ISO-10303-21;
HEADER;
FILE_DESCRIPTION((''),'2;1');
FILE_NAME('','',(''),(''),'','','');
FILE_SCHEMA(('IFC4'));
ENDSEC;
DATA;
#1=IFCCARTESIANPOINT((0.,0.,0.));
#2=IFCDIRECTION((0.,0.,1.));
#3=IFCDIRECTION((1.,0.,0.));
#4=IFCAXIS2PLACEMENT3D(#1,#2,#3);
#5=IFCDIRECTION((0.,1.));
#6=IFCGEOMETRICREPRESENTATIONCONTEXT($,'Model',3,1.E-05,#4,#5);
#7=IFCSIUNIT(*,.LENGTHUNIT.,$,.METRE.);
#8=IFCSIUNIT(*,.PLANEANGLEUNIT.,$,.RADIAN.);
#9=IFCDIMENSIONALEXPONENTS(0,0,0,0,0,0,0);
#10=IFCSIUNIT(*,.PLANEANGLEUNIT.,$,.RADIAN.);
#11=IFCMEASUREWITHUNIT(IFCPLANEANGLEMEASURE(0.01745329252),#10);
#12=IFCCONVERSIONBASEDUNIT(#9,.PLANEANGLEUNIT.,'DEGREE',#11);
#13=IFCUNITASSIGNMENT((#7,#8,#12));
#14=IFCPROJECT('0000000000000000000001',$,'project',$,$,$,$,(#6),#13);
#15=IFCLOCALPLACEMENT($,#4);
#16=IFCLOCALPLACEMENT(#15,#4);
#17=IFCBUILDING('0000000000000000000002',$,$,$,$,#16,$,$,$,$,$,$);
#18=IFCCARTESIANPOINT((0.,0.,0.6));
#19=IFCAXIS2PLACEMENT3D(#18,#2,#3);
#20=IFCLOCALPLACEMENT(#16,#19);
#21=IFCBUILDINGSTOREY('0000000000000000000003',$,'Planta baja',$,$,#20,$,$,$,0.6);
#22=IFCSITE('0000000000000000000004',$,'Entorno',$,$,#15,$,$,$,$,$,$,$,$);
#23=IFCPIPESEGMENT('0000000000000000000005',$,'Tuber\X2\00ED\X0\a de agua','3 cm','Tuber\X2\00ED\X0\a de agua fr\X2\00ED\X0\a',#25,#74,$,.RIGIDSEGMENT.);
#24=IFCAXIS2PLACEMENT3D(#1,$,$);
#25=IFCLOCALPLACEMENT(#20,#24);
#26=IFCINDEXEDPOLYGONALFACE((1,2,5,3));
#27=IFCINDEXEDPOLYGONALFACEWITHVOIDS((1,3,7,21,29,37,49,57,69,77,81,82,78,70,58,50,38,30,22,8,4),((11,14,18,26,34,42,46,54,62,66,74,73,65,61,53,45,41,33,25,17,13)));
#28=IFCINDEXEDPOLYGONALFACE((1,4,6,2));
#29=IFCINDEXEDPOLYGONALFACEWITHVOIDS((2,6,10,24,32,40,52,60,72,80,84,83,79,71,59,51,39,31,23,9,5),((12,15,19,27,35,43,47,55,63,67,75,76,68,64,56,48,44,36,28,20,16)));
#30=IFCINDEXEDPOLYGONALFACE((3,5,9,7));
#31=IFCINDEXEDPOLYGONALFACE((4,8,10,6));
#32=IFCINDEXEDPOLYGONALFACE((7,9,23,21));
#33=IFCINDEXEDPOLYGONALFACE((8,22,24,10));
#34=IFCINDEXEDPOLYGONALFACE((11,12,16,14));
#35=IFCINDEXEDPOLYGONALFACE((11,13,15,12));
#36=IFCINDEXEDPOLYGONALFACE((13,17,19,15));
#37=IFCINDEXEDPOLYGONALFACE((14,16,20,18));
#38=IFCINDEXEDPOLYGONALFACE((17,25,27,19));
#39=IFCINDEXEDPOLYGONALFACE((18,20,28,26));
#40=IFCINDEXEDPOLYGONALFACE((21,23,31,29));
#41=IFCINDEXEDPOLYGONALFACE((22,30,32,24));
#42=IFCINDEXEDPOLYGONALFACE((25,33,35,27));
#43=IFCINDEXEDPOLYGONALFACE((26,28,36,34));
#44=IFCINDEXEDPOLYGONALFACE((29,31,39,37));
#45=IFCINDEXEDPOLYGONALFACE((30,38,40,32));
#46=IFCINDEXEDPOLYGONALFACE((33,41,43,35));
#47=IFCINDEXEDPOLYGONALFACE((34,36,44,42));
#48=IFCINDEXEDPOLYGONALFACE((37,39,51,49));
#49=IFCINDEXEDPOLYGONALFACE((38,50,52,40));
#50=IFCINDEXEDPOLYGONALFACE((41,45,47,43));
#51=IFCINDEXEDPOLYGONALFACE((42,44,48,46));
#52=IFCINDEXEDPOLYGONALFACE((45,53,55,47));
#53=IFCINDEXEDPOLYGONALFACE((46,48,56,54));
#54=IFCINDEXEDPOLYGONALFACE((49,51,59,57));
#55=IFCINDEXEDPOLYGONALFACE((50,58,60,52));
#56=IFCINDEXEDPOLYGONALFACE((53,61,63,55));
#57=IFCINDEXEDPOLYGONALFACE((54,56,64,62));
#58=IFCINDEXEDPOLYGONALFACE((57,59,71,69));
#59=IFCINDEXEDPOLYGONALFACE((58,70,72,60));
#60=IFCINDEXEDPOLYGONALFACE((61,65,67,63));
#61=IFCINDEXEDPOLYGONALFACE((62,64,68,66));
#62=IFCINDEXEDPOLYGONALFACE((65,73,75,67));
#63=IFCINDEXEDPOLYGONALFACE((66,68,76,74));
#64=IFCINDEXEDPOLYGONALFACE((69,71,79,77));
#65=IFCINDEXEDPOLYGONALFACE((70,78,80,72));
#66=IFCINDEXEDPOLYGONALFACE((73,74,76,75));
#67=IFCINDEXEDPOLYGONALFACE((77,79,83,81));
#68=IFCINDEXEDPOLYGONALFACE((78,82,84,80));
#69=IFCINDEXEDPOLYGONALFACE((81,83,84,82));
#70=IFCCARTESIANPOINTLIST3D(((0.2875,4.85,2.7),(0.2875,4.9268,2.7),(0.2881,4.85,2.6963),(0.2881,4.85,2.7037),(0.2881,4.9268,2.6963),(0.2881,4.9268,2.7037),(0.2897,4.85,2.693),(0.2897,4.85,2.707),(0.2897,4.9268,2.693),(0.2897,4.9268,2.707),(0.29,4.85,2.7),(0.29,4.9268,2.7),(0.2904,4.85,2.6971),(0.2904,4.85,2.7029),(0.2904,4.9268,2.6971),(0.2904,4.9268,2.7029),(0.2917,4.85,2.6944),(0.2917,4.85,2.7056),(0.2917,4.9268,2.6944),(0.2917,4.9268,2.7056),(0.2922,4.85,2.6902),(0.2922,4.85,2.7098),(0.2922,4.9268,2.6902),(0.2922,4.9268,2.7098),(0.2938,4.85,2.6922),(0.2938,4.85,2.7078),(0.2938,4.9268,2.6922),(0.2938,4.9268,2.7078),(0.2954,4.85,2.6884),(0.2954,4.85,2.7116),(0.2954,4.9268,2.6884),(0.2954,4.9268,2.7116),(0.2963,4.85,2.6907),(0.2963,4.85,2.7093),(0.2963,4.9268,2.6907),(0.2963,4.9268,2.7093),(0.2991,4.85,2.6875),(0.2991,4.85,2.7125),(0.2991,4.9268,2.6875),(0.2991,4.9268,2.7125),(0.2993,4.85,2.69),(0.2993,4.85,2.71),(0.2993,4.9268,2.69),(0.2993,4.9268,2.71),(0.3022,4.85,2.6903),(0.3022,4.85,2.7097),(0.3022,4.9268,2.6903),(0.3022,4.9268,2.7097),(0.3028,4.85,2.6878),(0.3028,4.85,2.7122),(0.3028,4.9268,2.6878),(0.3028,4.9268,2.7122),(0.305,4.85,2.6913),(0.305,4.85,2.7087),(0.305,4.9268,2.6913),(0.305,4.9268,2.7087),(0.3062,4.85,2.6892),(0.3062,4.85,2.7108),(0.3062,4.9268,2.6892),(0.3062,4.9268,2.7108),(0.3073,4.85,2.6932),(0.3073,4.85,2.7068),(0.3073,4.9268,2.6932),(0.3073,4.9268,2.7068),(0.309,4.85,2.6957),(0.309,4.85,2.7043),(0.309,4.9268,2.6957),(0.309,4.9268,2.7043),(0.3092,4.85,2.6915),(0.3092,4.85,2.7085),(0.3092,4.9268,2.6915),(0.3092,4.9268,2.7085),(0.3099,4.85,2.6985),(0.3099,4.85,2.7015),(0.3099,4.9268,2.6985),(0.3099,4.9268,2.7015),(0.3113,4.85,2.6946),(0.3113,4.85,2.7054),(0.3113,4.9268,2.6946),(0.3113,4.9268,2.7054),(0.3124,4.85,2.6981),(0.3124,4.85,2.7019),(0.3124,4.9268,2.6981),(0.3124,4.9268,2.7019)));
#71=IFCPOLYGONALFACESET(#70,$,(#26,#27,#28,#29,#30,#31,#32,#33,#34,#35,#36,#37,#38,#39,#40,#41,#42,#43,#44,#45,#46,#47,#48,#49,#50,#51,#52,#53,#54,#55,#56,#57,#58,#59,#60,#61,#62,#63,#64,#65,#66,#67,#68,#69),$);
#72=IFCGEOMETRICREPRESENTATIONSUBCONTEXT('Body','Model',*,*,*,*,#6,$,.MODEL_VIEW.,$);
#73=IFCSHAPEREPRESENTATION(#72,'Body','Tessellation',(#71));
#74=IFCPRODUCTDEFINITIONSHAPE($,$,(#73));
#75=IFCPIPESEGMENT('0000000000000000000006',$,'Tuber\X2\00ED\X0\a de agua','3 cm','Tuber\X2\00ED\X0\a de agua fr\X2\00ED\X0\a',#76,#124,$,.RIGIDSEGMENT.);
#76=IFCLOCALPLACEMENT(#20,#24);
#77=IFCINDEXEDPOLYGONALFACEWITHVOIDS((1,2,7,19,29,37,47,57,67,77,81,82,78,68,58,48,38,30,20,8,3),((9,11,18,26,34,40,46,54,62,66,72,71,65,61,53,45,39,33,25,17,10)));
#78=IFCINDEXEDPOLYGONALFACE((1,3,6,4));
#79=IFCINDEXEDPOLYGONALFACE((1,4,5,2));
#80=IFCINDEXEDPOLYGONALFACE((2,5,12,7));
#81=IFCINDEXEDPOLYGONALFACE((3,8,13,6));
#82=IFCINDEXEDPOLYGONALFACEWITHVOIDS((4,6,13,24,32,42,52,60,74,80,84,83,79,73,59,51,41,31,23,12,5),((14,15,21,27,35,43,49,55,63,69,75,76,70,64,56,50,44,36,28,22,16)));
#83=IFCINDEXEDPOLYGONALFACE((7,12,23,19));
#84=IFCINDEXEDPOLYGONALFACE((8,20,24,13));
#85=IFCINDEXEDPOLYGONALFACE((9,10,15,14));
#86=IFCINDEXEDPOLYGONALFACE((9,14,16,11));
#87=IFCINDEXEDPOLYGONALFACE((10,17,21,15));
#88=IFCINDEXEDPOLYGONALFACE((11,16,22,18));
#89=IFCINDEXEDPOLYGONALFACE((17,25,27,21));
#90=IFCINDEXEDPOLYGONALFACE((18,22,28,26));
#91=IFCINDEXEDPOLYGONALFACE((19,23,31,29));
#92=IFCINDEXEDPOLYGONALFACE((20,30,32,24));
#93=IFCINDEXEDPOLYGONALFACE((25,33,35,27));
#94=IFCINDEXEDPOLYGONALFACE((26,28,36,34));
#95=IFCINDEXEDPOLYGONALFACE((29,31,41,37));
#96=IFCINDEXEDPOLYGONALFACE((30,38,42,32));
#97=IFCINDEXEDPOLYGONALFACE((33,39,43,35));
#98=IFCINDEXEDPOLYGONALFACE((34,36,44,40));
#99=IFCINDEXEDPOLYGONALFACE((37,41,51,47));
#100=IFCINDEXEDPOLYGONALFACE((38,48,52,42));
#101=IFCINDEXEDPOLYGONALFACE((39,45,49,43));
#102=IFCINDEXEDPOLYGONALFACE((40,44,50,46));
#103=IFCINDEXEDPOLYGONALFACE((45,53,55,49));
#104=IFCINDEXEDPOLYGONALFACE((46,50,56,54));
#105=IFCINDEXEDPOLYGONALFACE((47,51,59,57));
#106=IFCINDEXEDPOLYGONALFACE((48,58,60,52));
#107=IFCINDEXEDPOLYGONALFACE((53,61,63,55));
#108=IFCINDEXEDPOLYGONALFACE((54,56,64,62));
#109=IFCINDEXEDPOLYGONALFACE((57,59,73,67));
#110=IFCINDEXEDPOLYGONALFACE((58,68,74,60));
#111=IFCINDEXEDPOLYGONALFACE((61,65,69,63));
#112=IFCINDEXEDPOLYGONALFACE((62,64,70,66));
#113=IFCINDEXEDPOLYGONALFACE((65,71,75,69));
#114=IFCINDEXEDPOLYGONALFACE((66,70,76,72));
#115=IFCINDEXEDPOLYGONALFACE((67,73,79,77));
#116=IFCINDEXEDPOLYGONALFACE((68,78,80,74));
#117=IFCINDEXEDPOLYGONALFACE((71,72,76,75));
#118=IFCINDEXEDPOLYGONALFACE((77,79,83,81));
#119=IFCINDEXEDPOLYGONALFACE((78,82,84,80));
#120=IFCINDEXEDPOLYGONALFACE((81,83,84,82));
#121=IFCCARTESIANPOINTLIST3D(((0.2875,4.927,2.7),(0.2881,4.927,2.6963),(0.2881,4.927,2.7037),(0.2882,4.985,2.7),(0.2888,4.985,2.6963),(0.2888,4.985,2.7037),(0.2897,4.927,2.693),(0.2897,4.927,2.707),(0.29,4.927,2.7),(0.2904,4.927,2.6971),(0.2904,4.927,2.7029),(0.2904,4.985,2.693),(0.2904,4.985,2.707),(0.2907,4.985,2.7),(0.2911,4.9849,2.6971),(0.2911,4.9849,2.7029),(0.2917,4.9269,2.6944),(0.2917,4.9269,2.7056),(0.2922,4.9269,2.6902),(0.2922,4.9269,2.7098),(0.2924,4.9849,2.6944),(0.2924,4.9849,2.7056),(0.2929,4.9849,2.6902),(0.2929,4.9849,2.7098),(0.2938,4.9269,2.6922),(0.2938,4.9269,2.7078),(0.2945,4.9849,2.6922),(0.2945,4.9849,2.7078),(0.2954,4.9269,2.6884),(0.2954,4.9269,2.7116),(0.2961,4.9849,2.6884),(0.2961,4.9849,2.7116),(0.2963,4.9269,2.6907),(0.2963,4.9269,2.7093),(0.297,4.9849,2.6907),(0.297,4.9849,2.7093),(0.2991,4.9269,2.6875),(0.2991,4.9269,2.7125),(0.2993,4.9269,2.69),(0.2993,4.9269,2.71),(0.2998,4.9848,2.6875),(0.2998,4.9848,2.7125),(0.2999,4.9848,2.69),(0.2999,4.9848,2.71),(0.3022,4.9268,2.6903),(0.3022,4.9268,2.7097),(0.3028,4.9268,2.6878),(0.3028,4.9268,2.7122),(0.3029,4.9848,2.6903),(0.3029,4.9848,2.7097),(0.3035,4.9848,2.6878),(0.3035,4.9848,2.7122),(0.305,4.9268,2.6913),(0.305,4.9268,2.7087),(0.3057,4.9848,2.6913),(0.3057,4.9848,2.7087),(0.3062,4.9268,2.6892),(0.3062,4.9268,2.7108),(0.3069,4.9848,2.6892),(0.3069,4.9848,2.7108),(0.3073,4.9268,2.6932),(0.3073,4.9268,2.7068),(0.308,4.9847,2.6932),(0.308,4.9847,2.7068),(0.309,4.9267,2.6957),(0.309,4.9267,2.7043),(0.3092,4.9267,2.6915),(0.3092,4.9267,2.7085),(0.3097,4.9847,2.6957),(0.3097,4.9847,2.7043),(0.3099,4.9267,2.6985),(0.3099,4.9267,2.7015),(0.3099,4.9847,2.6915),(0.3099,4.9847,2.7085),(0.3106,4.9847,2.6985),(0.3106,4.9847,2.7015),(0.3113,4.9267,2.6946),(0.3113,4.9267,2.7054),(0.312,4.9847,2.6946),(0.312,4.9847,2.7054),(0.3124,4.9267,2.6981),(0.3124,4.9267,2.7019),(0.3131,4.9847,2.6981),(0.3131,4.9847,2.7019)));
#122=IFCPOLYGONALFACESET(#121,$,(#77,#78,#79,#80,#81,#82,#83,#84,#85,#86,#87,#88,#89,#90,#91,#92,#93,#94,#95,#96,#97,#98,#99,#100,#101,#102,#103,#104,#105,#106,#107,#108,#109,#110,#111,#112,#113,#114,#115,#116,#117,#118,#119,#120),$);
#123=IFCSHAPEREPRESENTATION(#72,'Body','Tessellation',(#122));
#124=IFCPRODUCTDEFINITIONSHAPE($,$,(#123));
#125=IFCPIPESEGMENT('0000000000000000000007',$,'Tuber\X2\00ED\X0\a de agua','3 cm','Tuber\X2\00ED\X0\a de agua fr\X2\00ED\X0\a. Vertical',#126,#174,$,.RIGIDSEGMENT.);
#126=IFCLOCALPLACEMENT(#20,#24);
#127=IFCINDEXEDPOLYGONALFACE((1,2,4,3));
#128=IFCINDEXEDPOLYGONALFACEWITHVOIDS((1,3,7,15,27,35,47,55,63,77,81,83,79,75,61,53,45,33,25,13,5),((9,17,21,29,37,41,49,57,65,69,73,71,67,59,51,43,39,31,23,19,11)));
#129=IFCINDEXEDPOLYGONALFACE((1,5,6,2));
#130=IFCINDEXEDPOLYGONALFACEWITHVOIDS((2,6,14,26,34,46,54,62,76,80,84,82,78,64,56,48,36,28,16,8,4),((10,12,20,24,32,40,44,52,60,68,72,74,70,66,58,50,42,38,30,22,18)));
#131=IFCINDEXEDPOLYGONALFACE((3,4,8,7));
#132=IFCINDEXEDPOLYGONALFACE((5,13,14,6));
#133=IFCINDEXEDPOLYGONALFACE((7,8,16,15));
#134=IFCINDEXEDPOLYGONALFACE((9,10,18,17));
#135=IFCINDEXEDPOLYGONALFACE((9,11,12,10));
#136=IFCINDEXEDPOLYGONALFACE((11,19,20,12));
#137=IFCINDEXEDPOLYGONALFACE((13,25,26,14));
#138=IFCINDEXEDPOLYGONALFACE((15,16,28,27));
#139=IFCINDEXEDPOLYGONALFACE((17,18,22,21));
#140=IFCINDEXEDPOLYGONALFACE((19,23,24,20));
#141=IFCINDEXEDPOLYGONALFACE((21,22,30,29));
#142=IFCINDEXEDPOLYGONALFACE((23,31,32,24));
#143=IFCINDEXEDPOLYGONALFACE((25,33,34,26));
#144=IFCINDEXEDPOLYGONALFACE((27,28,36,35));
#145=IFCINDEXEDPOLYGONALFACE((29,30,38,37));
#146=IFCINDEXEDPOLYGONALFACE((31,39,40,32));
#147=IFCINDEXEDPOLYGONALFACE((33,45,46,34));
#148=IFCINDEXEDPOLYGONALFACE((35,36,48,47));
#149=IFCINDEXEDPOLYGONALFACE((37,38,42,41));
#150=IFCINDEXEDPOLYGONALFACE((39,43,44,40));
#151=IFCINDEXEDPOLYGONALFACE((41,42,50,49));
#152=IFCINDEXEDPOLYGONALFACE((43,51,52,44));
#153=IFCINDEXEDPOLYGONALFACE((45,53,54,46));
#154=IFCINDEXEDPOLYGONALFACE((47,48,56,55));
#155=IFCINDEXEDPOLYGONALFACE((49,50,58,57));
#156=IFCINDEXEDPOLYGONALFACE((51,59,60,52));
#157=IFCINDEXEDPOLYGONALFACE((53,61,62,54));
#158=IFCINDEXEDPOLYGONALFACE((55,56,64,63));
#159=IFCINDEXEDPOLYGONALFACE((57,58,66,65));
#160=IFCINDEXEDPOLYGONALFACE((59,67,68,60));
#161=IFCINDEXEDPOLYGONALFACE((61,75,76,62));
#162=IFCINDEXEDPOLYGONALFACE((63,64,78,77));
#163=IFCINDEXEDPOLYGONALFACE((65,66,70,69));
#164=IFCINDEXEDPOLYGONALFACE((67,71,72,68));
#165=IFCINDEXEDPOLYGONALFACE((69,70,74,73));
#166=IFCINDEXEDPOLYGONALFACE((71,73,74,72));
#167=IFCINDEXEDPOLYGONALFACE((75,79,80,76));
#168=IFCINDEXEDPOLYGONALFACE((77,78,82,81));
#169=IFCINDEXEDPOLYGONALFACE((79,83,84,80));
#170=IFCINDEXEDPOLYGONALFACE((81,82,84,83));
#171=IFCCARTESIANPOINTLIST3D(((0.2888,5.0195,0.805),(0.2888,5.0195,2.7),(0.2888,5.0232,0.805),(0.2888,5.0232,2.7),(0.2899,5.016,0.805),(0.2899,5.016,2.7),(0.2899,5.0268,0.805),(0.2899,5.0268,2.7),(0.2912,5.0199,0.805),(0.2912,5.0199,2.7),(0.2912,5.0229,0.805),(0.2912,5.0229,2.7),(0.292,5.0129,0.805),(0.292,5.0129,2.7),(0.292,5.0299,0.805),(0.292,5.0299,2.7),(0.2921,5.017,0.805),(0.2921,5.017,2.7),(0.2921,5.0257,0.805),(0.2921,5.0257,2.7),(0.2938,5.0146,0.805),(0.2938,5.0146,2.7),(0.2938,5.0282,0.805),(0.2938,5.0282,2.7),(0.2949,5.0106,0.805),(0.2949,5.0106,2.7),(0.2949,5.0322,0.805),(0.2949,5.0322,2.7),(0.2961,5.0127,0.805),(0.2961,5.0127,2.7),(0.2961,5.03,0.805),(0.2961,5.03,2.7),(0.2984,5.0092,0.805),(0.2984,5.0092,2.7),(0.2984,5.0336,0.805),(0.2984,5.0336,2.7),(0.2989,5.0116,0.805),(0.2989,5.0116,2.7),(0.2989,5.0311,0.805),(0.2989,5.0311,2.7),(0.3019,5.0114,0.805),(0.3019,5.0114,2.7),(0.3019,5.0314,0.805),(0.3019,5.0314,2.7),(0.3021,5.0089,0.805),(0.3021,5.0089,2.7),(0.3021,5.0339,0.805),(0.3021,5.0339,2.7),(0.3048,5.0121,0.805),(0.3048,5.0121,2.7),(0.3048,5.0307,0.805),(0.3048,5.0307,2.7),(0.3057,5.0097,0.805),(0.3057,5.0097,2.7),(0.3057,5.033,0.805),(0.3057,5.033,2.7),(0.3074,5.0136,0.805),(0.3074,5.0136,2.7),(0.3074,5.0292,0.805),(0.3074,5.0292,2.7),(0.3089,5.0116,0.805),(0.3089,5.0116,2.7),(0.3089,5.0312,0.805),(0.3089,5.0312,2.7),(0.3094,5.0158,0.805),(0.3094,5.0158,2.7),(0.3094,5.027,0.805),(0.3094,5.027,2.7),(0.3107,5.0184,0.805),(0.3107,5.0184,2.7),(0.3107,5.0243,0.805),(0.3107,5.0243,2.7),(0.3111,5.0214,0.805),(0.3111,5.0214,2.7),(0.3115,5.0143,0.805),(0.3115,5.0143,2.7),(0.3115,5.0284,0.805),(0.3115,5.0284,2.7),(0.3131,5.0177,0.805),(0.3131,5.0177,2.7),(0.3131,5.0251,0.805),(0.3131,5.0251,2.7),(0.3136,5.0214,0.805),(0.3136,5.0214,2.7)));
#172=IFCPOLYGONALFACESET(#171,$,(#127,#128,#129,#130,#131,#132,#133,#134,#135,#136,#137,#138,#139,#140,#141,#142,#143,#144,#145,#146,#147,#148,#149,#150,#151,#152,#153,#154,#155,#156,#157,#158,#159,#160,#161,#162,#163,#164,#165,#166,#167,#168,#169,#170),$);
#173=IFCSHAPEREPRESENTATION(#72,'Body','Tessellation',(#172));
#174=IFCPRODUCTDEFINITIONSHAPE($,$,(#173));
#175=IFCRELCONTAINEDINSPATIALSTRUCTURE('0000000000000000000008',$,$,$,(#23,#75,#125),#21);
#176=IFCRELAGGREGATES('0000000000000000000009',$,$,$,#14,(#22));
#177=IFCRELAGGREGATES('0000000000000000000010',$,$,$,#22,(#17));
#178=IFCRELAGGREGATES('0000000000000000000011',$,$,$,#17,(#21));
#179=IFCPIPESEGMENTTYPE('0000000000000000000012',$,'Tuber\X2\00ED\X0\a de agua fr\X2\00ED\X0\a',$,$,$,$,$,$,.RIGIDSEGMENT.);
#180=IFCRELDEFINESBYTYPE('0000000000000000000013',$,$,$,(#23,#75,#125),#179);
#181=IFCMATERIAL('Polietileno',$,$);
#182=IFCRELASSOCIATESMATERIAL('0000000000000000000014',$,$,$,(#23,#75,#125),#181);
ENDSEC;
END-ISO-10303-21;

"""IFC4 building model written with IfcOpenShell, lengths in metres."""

from ifc_helpers import new_model, entity, si_unit, converted_unit, direction, frame, origin_with_axes, origin_2d_with_axis, place, context, subcontext, project, spatial, hollow_circle, extrude, material, type_object, element, save


model = new_model("IFC4")

# Units and contexts
model_context = context("Model", 3, precision=1e-05, world=origin_with_axes(), true_north=direction((0.0, 1.0)))
body_context = subcontext(model_context, "Body", "Model", "MODEL_VIEW")
ifc_project = project(units=[si_unit("LENGTHUNIT", "METRE"), si_unit("PLANEANGLEUNIT", "RADIAN"), converted_unit("PLANEANGLEUNIT", "DEGREE", entity("IfcPlaneAngleMeasure", 0.01745329252), si_unit("PLANEANGLEUNIT", "RADIAN"), dimensions=[0, 0, 0, 0, 0, 0, 0])], contexts=[model_context])

# Site, building, storey
site_placement = place(None, origin_with_axes())
site = spatial("IfcSite", under=ifc_project, at=site_placement, Name="Entorno")
building_placement = place(site_placement, origin_with_axes())
building = spatial("IfcBuilding", under=site, at=building_placement)
storey_placement = place(building_placement, frame((0.0, 0.0, 0.6), z_axis=(0.0, 0.0, 1.0), x_axis=(1.0, 0.0, 0.0)))
storey = spatial("IfcBuildingStorey", under=building, at=storey_placement, Name="Planta baja", Elevation=0.6)

# Pipe segments
ifc_material_1 = material(Name="Polietileno")
pipe_segment_type_1 = type_object("IfcPipeSegmentType", Name="Tubería de agua fría", PredefinedType="RIGIDSEGMENT")
pipe_segment_1_placement = place(storey_placement, frame((0.3, 4.85, 2.7), z_axis=(0.0, 1.0, 0.0), x_axis=(-1.0, 0.0, 0.0)))
element("IfcPipeSegment", 1, at=pipe_segment_1_placement, inside=storey, type_object=pipe_segment_type_1, material=ifc_material_1, Name="Tubería de agua", Description="3 cm", ObjectType="Tubería de agua fría", PredefinedType="RIGIDSEGMENT", context=body_context, shape_type="SweptSolid", body=[
    extrude(hollow_circle(Radius=0.0125, WallThickness=0.0025, at=origin_2d_with_axis()), origin_with_axes(), (0.0, 0.0, 1.0), 0.0768),
])
pipe_segment_2_placement = place(storey_placement, frame((0.3, 4.9268, 2.7), z_axis=(0.012002, 0.999928, 0.0), x_axis=(-0.999928, 0.012002, 0.0)))
element("IfcPipeSegment", 2, at=pipe_segment_2_placement, inside=storey, type_object=pipe_segment_type_1, material=ifc_material_1, Name="Tubería de agua", Description="3 cm", ObjectType="Tubería de agua fría", PredefinedType="RIGIDSEGMENT", context=body_context, shape_type="SweptSolid", body=[
    extrude(hollow_circle(Radius=0.0125, WallThickness=0.0025, at=origin_2d_with_axis()), origin_with_axes(), (0.0, 0.0, 1.0), 0.058),
])
pipe_segment_3_placement = place(storey_placement, frame((0.3011, 5.0214, 2.7), z_axis=(0.0, 0.0, -1.0), x_axis=(1.0, 0.0, 0.0)))
element("IfcPipeSegment", 3, at=pipe_segment_3_placement, inside=storey, type_object=pipe_segment_type_1, material=ifc_material_1, Name="Tubería de agua", Description="3 cm", ObjectType="Tubería de agua fría. Vertical", PredefinedType="RIGIDSEGMENT", context=body_context, shape_type="SweptSolid", body=[
    extrude(hollow_circle(Radius=0.0125, WallThickness=0.0025, at=origin_2d_with_axis()), origin_with_axes(), (0.0, 0.0, 1.0), 1.895),
])

save(model, "model.ifc")
